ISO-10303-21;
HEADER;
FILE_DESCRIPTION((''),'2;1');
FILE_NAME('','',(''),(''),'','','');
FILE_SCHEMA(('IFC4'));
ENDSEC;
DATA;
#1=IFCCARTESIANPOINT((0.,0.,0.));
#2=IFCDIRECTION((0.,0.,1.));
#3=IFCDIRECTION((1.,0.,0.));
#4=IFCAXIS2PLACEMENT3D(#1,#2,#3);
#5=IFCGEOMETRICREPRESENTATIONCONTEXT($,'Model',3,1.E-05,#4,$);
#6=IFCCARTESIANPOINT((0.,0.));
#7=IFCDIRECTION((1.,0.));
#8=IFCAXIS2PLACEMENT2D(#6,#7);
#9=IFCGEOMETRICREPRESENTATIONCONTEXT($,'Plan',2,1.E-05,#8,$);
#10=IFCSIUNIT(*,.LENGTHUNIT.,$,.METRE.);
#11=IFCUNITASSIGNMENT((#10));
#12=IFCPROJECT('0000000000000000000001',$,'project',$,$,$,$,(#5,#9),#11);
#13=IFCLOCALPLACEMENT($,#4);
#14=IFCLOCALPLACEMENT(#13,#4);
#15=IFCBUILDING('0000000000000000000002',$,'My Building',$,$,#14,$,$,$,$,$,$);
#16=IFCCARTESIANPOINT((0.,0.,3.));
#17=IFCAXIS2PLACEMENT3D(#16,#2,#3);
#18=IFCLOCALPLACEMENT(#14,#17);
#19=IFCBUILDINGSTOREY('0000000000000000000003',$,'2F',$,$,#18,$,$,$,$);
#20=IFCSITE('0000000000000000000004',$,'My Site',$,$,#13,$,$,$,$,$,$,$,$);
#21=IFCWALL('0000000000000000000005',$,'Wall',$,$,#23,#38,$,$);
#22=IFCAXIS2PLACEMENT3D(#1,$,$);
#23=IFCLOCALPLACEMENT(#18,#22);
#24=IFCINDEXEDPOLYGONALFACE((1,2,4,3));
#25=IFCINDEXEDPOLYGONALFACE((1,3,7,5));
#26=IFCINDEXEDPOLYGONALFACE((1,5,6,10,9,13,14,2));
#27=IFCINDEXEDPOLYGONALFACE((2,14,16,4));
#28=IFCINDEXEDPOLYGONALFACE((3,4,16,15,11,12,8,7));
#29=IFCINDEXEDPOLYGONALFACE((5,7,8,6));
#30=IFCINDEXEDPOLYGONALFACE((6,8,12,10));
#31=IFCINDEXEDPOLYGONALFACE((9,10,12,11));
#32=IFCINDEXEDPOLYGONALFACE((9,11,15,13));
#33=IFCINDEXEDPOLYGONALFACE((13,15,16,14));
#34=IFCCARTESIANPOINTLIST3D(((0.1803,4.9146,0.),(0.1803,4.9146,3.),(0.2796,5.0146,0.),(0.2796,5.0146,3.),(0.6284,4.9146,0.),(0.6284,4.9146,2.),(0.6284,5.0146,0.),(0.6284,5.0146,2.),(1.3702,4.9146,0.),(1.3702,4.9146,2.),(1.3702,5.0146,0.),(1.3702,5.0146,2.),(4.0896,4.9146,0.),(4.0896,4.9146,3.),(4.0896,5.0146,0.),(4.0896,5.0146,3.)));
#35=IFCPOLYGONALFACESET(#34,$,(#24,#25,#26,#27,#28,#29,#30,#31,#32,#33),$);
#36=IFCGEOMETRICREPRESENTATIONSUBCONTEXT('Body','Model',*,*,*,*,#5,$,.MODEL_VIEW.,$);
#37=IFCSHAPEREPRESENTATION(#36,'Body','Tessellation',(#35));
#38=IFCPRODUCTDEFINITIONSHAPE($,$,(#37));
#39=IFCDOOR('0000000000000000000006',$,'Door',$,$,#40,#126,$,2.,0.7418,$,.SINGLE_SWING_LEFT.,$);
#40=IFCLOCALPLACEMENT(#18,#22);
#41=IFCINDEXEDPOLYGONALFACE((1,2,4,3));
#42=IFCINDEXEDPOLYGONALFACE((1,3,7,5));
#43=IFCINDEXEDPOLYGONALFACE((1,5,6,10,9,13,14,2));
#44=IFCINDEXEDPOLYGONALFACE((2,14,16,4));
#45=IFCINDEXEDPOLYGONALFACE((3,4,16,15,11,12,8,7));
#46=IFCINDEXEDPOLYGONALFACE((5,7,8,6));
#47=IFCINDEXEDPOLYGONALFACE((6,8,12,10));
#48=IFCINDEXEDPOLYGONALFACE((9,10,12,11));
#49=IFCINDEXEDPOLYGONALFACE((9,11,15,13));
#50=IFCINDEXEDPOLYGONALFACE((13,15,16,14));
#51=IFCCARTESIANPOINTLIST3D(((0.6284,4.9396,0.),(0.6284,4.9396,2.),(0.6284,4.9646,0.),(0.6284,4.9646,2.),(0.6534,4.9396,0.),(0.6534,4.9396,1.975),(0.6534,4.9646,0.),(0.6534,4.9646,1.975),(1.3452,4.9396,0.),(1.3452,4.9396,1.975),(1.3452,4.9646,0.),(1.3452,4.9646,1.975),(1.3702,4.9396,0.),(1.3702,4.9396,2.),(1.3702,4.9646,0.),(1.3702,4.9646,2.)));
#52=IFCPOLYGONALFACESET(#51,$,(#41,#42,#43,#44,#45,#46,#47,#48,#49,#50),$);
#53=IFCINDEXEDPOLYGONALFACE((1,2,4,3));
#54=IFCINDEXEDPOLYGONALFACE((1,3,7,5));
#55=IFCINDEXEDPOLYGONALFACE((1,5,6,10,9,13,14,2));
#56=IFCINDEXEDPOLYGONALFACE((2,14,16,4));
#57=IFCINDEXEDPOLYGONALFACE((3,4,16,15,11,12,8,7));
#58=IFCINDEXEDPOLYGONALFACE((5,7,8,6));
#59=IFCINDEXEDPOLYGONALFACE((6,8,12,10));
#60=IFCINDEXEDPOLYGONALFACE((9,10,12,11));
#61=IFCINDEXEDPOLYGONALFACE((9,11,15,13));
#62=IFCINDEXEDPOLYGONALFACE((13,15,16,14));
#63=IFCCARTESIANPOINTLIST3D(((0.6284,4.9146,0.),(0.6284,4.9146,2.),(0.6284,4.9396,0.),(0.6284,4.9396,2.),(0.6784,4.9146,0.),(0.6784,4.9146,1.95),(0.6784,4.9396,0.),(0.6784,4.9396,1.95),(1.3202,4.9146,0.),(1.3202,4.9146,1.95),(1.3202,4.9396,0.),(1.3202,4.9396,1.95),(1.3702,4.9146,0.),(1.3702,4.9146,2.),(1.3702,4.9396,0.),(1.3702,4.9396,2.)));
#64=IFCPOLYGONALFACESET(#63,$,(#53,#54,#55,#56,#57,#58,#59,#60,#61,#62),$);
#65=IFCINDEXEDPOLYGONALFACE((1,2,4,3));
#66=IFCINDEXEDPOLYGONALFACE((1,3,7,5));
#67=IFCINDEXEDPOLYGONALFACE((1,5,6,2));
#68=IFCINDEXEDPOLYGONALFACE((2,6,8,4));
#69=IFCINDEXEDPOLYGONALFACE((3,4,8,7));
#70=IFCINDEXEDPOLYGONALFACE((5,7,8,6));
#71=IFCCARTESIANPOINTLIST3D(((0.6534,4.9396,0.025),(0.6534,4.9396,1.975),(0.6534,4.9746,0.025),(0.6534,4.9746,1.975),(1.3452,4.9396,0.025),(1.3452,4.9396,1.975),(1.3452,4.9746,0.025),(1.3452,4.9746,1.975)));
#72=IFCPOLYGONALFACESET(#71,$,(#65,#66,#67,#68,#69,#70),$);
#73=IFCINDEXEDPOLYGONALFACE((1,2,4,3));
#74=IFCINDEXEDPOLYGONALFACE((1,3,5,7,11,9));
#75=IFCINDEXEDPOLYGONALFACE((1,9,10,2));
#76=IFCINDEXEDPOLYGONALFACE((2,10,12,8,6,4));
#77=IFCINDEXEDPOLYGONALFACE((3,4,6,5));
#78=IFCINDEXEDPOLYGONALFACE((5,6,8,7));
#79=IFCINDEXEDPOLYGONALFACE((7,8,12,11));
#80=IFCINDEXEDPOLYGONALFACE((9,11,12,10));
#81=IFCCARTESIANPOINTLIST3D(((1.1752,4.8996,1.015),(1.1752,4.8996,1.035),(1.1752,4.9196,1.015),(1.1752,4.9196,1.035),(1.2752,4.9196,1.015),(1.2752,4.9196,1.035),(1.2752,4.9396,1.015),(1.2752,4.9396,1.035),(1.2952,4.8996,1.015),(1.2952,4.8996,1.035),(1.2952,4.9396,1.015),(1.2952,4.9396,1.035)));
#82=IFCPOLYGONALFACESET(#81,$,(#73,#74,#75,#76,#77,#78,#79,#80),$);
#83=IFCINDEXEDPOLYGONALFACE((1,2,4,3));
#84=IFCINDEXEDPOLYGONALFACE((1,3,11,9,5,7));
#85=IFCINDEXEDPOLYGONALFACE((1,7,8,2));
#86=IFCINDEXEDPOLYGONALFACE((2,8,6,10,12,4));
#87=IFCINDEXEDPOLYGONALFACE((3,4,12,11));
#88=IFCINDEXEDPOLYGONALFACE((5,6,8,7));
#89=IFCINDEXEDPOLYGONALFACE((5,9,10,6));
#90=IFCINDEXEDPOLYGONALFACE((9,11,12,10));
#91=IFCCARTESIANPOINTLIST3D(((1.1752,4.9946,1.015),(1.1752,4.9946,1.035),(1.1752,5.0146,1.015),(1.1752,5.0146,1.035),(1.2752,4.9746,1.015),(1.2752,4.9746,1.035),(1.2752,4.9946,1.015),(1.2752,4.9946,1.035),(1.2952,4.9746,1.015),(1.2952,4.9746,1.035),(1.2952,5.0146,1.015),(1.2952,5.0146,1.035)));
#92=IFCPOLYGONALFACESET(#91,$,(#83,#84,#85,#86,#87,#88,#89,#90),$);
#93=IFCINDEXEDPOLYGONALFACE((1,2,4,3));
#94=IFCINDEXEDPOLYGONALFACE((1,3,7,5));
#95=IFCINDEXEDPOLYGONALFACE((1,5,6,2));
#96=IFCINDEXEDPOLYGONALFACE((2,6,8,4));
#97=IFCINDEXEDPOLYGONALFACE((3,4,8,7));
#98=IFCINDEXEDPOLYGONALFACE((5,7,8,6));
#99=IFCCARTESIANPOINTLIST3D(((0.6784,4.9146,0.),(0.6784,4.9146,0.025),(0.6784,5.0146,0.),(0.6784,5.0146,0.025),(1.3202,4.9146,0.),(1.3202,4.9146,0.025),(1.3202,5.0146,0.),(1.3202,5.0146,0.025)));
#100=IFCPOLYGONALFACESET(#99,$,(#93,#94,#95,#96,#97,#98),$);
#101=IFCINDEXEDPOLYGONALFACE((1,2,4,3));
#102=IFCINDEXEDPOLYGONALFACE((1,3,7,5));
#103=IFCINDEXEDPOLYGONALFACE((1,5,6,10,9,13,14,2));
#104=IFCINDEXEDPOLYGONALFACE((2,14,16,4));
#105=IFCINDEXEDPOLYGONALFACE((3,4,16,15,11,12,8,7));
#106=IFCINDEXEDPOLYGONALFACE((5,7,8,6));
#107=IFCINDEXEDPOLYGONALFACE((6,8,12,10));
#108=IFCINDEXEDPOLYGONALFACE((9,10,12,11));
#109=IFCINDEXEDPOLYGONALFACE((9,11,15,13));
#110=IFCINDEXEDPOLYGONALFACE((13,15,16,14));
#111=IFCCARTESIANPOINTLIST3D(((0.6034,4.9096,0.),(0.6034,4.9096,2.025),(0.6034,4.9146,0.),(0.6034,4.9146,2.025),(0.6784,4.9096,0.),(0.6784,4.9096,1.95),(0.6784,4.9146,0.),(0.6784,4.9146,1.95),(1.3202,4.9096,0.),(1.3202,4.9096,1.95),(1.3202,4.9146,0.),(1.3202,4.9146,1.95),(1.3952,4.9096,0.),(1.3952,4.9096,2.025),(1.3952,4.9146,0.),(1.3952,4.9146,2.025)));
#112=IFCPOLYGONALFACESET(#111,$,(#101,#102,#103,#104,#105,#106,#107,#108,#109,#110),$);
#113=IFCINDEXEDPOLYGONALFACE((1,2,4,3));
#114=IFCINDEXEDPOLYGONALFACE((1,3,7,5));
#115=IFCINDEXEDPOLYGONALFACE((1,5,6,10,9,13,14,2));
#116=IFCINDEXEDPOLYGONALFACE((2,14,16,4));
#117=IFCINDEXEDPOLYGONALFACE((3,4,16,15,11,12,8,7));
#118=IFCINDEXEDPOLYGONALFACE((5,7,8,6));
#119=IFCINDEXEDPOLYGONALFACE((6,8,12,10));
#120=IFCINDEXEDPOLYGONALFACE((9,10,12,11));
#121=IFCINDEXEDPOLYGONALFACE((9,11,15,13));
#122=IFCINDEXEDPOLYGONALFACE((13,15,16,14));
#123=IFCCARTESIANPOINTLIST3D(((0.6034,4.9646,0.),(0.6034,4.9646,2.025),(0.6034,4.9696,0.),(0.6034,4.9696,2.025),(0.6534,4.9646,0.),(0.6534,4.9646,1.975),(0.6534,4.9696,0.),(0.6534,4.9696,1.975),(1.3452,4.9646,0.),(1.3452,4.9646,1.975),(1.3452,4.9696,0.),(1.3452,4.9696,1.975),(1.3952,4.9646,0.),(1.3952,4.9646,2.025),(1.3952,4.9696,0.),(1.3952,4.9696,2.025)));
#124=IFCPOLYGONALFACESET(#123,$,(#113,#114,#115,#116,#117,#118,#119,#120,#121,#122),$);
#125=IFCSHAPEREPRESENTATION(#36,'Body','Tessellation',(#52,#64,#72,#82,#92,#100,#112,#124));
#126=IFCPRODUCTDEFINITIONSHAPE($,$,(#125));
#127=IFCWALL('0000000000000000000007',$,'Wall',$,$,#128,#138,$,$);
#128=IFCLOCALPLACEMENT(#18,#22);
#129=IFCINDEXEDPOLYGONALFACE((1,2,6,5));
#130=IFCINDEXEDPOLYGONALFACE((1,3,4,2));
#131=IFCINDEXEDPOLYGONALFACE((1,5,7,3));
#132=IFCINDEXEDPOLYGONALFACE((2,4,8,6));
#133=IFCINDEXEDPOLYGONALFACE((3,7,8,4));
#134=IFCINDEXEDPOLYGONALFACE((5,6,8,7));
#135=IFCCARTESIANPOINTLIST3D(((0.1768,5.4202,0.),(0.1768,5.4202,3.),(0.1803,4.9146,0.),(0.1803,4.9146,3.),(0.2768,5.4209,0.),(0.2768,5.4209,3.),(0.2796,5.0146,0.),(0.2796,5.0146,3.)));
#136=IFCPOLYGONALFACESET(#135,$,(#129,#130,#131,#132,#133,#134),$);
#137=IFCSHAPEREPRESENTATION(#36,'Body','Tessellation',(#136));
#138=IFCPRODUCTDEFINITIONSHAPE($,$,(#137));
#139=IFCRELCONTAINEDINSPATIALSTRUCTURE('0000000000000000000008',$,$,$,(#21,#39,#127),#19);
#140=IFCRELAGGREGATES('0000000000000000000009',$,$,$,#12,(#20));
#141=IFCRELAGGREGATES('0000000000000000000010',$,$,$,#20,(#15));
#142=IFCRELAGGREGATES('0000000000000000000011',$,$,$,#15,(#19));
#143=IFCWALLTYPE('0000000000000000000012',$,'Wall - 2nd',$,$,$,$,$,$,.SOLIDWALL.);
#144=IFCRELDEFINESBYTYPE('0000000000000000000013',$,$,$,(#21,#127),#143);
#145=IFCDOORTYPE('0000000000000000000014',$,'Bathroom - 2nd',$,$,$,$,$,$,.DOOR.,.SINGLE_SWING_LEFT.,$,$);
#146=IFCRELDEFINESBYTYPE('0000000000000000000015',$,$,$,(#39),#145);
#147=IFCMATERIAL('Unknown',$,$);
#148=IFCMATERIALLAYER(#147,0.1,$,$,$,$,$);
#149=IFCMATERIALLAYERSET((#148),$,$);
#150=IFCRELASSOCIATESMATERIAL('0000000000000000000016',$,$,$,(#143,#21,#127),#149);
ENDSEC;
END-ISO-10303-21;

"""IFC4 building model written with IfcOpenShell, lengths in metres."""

from ifc_helpers import new_model, entity, si_unit, frame, origin_with_axes, origin_2d_with_axis, place, context, subcontext, project, spatial, line, indexed_curve, outline, extrude, shape, source, transform, mapped, material, layer, layer_set, layer_usage, type_object, type_shapes, element, fill, save


model = new_model("IFC4")

# Units and contexts
model_context = context("Model", 3, precision=1e-05, world=origin_with_axes())
plan_context = context("Plan", 2, precision=1e-05, world=origin_2d_with_axis())
body_context_1 = subcontext(model_context, "Body", "Model", "MODEL_VIEW")
body_context_2 = subcontext(plan_context, "Body", "Plan", "PLAN_VIEW")
ifc_project = project(units=[si_unit("LENGTHUNIT", "METRE")], contexts=[model_context, plan_context])

# Site, building, storey
site_placement = place(None, origin_with_axes())
site = spatial("IfcSite", under=ifc_project, at=site_placement, Name="My Site")
building_placement = place(site_placement, origin_with_axes())
building = spatial("IfcBuilding", under=site, at=building_placement, Name="My Building")
storey_placement = place(building_placement, frame((0.0, 0.0, 3.0), z_axis=(0.0, 0.0, 1.0), x_axis=(1.0, 0.0, 0.0)))
storey = spatial("IfcBuildingStorey", under=building, at=storey_placement, Name="2F")

# Shared definitions
ifc_material = material(Name="Unknown")

# Shared definitions
ifc_layer_1 = layer(ifc_material, 0.1)
ifc_layer_set_1 = layer_set([ifc_layer_1])
wall_type = type_object("IfcWallType", Name="Wall - 2nd", PredefinedType="SOLIDWALL", material=ifc_layer_set_1)

# Wall, opening, door
ifc_layer_usage_1 = layer_usage(ifc_layer_set_1, "AXIS2", "POSITIVE", 0.0)
wall_1_placement = place(storey_placement, frame((4.0896, 5.0146, 0.0), z_axis=(0.0, 0.0, 1.0), x_axis=(-1.0, 0.0, 0.0)))
wall_1 = element("IfcWall", 1, at=wall_1_placement, inside=storey, type_object=wall_type, material=ifc_layer_usage_1, Name="Wall", context=body_context_1, shape_type="SweptSolid", body=[
    extrude(outline(indexed_curve([(0.0, 0.0), (0.0, 0.1), (3.9093, 0.1), (3.81, 0.0)], segments=[line(1, 2, 3, 4, 1)])), origin_with_axes(), (0.0, 0.0, 1.0), 3.0),
])
shared_shape_1 = source(origin_with_axes(), body_context_1, "Body", "SweptSolid", [
    extrude(outline(indexed_curve([(0.0, 0.0), (0.7418, 0.0), (0.7418, 2.0), (0.0, 2.0)], segments=[line(1, 2, 3, 4, 1)])), frame((0.0, -0.6, 0.0), z_axis=(0.0, -1.0, 0.0), x_axis=(1.0, 0.0, 0.0)), (0.0, 0.0, -1.0), 1.2),
])
opening_1_placement = place(wall_1_placement, frame((3.4612, 0.1, 0.0), z_axis=(0.0, 0.0, 1.0), x_axis=(-1.0, 0.0, 0.0)))
opening_1 = element("IfcOpeningElement", 2, at=opening_1_placement, cuts=wall_1, PredefinedType="OPENING", context=body_context_1, shape_type="MappedRepresentation", body=[
    mapped(shared_shape_1, transform((0.0, 0.0, 0.0), x_axis=(1.0, 0.0, 0.0), y_axis=(0.0, 1.0, 0.0), z_axis=(0.0, 0.0, 1.0), scale=1.0)),
])
door_type_1 = type_object("IfcDoorType", Name="Bathroom - 2nd", OperationType="SINGLE_SWING_LEFT", PredefinedType="DOOR")
shared_shape_2 = source(origin_with_axes(), body_context_1, "Body", "SweptSolid", [
    extrude(outline(indexed_curve([(0.0, 0.0), (0.0, 2.0), (0.7418, 2.0), (0.7418, 0.0), (0.7168, 0.0), (0.7168, 1.975), (0.025, 1.975), (0.025, 0.0)], segments=[line(1, 2, 3, 4, 5, 6, 7, 8, 1)])), frame((0.0, 0.025, 0.0), z_axis=(0.0, -1.0, 0.0), x_axis=(1.0, 0.0, 0.0)), (0.0, 0.0, -1.0), 0.025),
    extrude(outline(indexed_curve([(0.0, 0.0), (0.0, 2.0), (0.7418, 2.0), (0.7418, 0.0), (0.6918, 0.0), (0.6918, 1.95), (0.05, 1.95), (0.05, 0.0)], segments=[line(1, 2, 3, 4, 5, 6, 7, 8, 1)])), frame((0.0, 0.0, 0.0), z_axis=(0.0, -1.0, 0.0), x_axis=(1.0, 0.0, 0.0)), (0.0, 0.0, -1.0), 0.025),
    extrude(outline(indexed_curve([(0.0, 0.0), (0.6918, 0.0), (0.6918, 0.035), (0.0, 0.035)], segments=[line(1, 2, 3, 4, 1)])), frame((0.025, 0.025, 0.025), z_axis=(0.0, 0.0, 1.0), x_axis=(1.0, 0.0, 0.0)), (0.0, 0.0, 1.0), 1.95),
    extrude(outline(indexed_curve([(0.0, 0.0), (0.0, -0.04), (-0.12, -0.04), (-0.12, -0.02), (-0.02, -0.02), (-0.02, 0.0)], segments=[line(1, 2, 3, 4, 5, 6, 1)])), frame((0.6668, 0.025, 1.015), z_axis=(0.0, 0.0, 1.0), x_axis=(1.0, 0.0, 0.0)), (0.0, 0.0, 1.0), 0.02),
    extrude(outline(indexed_curve([(0.0, 0.0), (0.0, 0.04), (-0.12, 0.04), (-0.12, 0.02), (-0.02, 0.02), (-0.02, 0.0)], segments=[line(1, 2, 3, 4, 5, 6, 1)])), frame((0.6668, 0.06, 1.015), z_axis=(0.0, 0.0, 1.0), x_axis=(1.0, 0.0, 0.0)), (0.0, 0.0, 1.0), 0.02),
    extrude(outline(indexed_curve([(0.0, 0.0), (0.6418, 0.0), (0.6418, 0.1), (0.0, 0.1)], segments=[line(1, 2, 3, 4, 1)])), frame((0.05, 0.0, 0.0), z_axis=(0.0, 0.0, 1.0), x_axis=(1.0, 0.0, 0.0)), (0.0, 0.0, 1.0), 0.025),
    extrude(outline(indexed_curve([(0.0, 0.0), (0.0, 2.025), (0.7918, 2.025), (0.7918, 0.0), (0.7168, 0.0), (0.7168, 1.95), (0.075, 1.95), (0.075, 0.0)], segments=[line(1, 2, 3, 4, 5, 6, 7, 8, 1)])), frame((-0.025, -0.005, 0.0), z_axis=(0.0, -1.0, 0.0), x_axis=(1.0, 0.0, 0.0)), (0.0, 0.0, -1.0), 0.005),
    extrude(outline(indexed_curve([(0.0, 0.0), (0.0, 2.025), (0.7918, 2.025), (0.7918, 0.0), (0.7418, 0.0), (0.7418, 1.975), (0.05, 1.975), (0.05, 0.0)], segments=[line(1, 2, 3, 4, 5, 6, 7, 8, 1)])), frame((-0.025, 0.05, 0.0), z_axis=(0.0, -1.0, 0.0), x_axis=(1.0, 0.0, 0.0)), (0.0, 0.0, -1.0), 0.005),
])
shared_shape_3 = source(origin_with_axes(), body_context_2, "Body", "Curve2D", [
    entity("IfcIndexedPolyCurve", entity("IfcCartesianPointList2D", [[0.0, 0.0], [0.0, 0.05], [0.025, 0.05], [0.025, 0.025], [0.05, 0.025], [0.05, 0.0]]), [entity("IfcLineIndex", [1, 2, 3, 4, 5, 6, 1])]),
    entity("IfcIndexedPolyCurve", entity("IfcCartesianPointList2D", [[0.7418, 0.0], [0.7418, 0.05], [0.7168, 0.05], [0.7168, 0.025], [0.6918, 0.025], [0.6918, 0.0]]), [entity("IfcLineIndex", [1, 2, 3, 4, 5, 6, 1])]),
    entity("IfcTrimmedCurve", entity("IfcEllipse", entity("IfcAxis2Placement2D", entity("IfcCartesianPoint", [0.06, 0.05]), entity("IfcDirection", [1.0, 0.0])), 0.6568, 0.6918), [entity("IfcCartesianPoint", [0.7168, 0.05])], [entity("IfcCartesianPoint", [0.06, 0.7418])], True, "CARTESIAN"),
    entity("IfcIndexedPolyCurve", entity("IfcCartesianPointList2D", [[0.025, 0.05], [0.06, 0.05], [0.06, 0.7418], [0.025, 0.7418]]), [entity("IfcLineIndex", [1, 2, 3, 4, 1])]),
])
type_shapes(door_type_1, [shared_shape_2, shared_shape_3])
door_1_placement = place(opening_1_placement, frame((0.0, 0.0, 0.0), z_axis=(0.0, 0.0, 1.0), x_axis=(1.0, 0.0, 0.0)))
door_1 = element("IfcDoor", 3, at=door_1_placement, inside=storey, type_object=door_type_1, Name="Door", OperationType="SINGLE_SWING_LEFT", OverallHeight=2.0, OverallWidth=0.7418, shapes=[
    shape(body_context_1, "Body", "MappedRepresentation", [mapped(shared_shape_2, transform((0.0, 0.0, 0.0), x_axis=(1.0, 0.0, 0.0), y_axis=(0.0, 1.0, 0.0), z_axis=(0.0, 0.0, 1.0), scale=1.0))]),
    shape(body_context_2, "Body", "MappedRepresentation", [mapped(shared_shape_3, transform((0.0, 0.0, 0.0), x_axis=(1.0, 0.0, 0.0), y_axis=(0.0, 1.0, 0.0), z_axis=(0.0, 0.0, 1.0), scale=1.0))]),
])
fill(opening_1, door_1)

# Wall
ifc_layer_usage_2 = layer_usage(ifc_layer_set_1, "AXIS2", "POSITIVE", 0.0)
wall_2_placement = place(storey_placement, frame((0.2796, 5.0146, 0.0), z_axis=(0.0, 0.0, 1.0), x_axis=(-0.006807, 0.999977, 0.0)))
element("IfcWall", 4, at=wall_2_placement, inside=storey, type_object=wall_type, material=ifc_layer_usage_2, Name="Wall", context=body_context_1, shape_type="SweptSolid", body=[
    extrude(outline(indexed_curve([(0.0, 0.0), (-0.0993, 0.1), (0.4064, 0.1), (0.4064, 0.0)], segments=[line(1, 2, 3, 4, 1)])), origin_with_axes(), (0.0, 0.0, 1.0), 3.0),
])

save(model, "model.ifc")
